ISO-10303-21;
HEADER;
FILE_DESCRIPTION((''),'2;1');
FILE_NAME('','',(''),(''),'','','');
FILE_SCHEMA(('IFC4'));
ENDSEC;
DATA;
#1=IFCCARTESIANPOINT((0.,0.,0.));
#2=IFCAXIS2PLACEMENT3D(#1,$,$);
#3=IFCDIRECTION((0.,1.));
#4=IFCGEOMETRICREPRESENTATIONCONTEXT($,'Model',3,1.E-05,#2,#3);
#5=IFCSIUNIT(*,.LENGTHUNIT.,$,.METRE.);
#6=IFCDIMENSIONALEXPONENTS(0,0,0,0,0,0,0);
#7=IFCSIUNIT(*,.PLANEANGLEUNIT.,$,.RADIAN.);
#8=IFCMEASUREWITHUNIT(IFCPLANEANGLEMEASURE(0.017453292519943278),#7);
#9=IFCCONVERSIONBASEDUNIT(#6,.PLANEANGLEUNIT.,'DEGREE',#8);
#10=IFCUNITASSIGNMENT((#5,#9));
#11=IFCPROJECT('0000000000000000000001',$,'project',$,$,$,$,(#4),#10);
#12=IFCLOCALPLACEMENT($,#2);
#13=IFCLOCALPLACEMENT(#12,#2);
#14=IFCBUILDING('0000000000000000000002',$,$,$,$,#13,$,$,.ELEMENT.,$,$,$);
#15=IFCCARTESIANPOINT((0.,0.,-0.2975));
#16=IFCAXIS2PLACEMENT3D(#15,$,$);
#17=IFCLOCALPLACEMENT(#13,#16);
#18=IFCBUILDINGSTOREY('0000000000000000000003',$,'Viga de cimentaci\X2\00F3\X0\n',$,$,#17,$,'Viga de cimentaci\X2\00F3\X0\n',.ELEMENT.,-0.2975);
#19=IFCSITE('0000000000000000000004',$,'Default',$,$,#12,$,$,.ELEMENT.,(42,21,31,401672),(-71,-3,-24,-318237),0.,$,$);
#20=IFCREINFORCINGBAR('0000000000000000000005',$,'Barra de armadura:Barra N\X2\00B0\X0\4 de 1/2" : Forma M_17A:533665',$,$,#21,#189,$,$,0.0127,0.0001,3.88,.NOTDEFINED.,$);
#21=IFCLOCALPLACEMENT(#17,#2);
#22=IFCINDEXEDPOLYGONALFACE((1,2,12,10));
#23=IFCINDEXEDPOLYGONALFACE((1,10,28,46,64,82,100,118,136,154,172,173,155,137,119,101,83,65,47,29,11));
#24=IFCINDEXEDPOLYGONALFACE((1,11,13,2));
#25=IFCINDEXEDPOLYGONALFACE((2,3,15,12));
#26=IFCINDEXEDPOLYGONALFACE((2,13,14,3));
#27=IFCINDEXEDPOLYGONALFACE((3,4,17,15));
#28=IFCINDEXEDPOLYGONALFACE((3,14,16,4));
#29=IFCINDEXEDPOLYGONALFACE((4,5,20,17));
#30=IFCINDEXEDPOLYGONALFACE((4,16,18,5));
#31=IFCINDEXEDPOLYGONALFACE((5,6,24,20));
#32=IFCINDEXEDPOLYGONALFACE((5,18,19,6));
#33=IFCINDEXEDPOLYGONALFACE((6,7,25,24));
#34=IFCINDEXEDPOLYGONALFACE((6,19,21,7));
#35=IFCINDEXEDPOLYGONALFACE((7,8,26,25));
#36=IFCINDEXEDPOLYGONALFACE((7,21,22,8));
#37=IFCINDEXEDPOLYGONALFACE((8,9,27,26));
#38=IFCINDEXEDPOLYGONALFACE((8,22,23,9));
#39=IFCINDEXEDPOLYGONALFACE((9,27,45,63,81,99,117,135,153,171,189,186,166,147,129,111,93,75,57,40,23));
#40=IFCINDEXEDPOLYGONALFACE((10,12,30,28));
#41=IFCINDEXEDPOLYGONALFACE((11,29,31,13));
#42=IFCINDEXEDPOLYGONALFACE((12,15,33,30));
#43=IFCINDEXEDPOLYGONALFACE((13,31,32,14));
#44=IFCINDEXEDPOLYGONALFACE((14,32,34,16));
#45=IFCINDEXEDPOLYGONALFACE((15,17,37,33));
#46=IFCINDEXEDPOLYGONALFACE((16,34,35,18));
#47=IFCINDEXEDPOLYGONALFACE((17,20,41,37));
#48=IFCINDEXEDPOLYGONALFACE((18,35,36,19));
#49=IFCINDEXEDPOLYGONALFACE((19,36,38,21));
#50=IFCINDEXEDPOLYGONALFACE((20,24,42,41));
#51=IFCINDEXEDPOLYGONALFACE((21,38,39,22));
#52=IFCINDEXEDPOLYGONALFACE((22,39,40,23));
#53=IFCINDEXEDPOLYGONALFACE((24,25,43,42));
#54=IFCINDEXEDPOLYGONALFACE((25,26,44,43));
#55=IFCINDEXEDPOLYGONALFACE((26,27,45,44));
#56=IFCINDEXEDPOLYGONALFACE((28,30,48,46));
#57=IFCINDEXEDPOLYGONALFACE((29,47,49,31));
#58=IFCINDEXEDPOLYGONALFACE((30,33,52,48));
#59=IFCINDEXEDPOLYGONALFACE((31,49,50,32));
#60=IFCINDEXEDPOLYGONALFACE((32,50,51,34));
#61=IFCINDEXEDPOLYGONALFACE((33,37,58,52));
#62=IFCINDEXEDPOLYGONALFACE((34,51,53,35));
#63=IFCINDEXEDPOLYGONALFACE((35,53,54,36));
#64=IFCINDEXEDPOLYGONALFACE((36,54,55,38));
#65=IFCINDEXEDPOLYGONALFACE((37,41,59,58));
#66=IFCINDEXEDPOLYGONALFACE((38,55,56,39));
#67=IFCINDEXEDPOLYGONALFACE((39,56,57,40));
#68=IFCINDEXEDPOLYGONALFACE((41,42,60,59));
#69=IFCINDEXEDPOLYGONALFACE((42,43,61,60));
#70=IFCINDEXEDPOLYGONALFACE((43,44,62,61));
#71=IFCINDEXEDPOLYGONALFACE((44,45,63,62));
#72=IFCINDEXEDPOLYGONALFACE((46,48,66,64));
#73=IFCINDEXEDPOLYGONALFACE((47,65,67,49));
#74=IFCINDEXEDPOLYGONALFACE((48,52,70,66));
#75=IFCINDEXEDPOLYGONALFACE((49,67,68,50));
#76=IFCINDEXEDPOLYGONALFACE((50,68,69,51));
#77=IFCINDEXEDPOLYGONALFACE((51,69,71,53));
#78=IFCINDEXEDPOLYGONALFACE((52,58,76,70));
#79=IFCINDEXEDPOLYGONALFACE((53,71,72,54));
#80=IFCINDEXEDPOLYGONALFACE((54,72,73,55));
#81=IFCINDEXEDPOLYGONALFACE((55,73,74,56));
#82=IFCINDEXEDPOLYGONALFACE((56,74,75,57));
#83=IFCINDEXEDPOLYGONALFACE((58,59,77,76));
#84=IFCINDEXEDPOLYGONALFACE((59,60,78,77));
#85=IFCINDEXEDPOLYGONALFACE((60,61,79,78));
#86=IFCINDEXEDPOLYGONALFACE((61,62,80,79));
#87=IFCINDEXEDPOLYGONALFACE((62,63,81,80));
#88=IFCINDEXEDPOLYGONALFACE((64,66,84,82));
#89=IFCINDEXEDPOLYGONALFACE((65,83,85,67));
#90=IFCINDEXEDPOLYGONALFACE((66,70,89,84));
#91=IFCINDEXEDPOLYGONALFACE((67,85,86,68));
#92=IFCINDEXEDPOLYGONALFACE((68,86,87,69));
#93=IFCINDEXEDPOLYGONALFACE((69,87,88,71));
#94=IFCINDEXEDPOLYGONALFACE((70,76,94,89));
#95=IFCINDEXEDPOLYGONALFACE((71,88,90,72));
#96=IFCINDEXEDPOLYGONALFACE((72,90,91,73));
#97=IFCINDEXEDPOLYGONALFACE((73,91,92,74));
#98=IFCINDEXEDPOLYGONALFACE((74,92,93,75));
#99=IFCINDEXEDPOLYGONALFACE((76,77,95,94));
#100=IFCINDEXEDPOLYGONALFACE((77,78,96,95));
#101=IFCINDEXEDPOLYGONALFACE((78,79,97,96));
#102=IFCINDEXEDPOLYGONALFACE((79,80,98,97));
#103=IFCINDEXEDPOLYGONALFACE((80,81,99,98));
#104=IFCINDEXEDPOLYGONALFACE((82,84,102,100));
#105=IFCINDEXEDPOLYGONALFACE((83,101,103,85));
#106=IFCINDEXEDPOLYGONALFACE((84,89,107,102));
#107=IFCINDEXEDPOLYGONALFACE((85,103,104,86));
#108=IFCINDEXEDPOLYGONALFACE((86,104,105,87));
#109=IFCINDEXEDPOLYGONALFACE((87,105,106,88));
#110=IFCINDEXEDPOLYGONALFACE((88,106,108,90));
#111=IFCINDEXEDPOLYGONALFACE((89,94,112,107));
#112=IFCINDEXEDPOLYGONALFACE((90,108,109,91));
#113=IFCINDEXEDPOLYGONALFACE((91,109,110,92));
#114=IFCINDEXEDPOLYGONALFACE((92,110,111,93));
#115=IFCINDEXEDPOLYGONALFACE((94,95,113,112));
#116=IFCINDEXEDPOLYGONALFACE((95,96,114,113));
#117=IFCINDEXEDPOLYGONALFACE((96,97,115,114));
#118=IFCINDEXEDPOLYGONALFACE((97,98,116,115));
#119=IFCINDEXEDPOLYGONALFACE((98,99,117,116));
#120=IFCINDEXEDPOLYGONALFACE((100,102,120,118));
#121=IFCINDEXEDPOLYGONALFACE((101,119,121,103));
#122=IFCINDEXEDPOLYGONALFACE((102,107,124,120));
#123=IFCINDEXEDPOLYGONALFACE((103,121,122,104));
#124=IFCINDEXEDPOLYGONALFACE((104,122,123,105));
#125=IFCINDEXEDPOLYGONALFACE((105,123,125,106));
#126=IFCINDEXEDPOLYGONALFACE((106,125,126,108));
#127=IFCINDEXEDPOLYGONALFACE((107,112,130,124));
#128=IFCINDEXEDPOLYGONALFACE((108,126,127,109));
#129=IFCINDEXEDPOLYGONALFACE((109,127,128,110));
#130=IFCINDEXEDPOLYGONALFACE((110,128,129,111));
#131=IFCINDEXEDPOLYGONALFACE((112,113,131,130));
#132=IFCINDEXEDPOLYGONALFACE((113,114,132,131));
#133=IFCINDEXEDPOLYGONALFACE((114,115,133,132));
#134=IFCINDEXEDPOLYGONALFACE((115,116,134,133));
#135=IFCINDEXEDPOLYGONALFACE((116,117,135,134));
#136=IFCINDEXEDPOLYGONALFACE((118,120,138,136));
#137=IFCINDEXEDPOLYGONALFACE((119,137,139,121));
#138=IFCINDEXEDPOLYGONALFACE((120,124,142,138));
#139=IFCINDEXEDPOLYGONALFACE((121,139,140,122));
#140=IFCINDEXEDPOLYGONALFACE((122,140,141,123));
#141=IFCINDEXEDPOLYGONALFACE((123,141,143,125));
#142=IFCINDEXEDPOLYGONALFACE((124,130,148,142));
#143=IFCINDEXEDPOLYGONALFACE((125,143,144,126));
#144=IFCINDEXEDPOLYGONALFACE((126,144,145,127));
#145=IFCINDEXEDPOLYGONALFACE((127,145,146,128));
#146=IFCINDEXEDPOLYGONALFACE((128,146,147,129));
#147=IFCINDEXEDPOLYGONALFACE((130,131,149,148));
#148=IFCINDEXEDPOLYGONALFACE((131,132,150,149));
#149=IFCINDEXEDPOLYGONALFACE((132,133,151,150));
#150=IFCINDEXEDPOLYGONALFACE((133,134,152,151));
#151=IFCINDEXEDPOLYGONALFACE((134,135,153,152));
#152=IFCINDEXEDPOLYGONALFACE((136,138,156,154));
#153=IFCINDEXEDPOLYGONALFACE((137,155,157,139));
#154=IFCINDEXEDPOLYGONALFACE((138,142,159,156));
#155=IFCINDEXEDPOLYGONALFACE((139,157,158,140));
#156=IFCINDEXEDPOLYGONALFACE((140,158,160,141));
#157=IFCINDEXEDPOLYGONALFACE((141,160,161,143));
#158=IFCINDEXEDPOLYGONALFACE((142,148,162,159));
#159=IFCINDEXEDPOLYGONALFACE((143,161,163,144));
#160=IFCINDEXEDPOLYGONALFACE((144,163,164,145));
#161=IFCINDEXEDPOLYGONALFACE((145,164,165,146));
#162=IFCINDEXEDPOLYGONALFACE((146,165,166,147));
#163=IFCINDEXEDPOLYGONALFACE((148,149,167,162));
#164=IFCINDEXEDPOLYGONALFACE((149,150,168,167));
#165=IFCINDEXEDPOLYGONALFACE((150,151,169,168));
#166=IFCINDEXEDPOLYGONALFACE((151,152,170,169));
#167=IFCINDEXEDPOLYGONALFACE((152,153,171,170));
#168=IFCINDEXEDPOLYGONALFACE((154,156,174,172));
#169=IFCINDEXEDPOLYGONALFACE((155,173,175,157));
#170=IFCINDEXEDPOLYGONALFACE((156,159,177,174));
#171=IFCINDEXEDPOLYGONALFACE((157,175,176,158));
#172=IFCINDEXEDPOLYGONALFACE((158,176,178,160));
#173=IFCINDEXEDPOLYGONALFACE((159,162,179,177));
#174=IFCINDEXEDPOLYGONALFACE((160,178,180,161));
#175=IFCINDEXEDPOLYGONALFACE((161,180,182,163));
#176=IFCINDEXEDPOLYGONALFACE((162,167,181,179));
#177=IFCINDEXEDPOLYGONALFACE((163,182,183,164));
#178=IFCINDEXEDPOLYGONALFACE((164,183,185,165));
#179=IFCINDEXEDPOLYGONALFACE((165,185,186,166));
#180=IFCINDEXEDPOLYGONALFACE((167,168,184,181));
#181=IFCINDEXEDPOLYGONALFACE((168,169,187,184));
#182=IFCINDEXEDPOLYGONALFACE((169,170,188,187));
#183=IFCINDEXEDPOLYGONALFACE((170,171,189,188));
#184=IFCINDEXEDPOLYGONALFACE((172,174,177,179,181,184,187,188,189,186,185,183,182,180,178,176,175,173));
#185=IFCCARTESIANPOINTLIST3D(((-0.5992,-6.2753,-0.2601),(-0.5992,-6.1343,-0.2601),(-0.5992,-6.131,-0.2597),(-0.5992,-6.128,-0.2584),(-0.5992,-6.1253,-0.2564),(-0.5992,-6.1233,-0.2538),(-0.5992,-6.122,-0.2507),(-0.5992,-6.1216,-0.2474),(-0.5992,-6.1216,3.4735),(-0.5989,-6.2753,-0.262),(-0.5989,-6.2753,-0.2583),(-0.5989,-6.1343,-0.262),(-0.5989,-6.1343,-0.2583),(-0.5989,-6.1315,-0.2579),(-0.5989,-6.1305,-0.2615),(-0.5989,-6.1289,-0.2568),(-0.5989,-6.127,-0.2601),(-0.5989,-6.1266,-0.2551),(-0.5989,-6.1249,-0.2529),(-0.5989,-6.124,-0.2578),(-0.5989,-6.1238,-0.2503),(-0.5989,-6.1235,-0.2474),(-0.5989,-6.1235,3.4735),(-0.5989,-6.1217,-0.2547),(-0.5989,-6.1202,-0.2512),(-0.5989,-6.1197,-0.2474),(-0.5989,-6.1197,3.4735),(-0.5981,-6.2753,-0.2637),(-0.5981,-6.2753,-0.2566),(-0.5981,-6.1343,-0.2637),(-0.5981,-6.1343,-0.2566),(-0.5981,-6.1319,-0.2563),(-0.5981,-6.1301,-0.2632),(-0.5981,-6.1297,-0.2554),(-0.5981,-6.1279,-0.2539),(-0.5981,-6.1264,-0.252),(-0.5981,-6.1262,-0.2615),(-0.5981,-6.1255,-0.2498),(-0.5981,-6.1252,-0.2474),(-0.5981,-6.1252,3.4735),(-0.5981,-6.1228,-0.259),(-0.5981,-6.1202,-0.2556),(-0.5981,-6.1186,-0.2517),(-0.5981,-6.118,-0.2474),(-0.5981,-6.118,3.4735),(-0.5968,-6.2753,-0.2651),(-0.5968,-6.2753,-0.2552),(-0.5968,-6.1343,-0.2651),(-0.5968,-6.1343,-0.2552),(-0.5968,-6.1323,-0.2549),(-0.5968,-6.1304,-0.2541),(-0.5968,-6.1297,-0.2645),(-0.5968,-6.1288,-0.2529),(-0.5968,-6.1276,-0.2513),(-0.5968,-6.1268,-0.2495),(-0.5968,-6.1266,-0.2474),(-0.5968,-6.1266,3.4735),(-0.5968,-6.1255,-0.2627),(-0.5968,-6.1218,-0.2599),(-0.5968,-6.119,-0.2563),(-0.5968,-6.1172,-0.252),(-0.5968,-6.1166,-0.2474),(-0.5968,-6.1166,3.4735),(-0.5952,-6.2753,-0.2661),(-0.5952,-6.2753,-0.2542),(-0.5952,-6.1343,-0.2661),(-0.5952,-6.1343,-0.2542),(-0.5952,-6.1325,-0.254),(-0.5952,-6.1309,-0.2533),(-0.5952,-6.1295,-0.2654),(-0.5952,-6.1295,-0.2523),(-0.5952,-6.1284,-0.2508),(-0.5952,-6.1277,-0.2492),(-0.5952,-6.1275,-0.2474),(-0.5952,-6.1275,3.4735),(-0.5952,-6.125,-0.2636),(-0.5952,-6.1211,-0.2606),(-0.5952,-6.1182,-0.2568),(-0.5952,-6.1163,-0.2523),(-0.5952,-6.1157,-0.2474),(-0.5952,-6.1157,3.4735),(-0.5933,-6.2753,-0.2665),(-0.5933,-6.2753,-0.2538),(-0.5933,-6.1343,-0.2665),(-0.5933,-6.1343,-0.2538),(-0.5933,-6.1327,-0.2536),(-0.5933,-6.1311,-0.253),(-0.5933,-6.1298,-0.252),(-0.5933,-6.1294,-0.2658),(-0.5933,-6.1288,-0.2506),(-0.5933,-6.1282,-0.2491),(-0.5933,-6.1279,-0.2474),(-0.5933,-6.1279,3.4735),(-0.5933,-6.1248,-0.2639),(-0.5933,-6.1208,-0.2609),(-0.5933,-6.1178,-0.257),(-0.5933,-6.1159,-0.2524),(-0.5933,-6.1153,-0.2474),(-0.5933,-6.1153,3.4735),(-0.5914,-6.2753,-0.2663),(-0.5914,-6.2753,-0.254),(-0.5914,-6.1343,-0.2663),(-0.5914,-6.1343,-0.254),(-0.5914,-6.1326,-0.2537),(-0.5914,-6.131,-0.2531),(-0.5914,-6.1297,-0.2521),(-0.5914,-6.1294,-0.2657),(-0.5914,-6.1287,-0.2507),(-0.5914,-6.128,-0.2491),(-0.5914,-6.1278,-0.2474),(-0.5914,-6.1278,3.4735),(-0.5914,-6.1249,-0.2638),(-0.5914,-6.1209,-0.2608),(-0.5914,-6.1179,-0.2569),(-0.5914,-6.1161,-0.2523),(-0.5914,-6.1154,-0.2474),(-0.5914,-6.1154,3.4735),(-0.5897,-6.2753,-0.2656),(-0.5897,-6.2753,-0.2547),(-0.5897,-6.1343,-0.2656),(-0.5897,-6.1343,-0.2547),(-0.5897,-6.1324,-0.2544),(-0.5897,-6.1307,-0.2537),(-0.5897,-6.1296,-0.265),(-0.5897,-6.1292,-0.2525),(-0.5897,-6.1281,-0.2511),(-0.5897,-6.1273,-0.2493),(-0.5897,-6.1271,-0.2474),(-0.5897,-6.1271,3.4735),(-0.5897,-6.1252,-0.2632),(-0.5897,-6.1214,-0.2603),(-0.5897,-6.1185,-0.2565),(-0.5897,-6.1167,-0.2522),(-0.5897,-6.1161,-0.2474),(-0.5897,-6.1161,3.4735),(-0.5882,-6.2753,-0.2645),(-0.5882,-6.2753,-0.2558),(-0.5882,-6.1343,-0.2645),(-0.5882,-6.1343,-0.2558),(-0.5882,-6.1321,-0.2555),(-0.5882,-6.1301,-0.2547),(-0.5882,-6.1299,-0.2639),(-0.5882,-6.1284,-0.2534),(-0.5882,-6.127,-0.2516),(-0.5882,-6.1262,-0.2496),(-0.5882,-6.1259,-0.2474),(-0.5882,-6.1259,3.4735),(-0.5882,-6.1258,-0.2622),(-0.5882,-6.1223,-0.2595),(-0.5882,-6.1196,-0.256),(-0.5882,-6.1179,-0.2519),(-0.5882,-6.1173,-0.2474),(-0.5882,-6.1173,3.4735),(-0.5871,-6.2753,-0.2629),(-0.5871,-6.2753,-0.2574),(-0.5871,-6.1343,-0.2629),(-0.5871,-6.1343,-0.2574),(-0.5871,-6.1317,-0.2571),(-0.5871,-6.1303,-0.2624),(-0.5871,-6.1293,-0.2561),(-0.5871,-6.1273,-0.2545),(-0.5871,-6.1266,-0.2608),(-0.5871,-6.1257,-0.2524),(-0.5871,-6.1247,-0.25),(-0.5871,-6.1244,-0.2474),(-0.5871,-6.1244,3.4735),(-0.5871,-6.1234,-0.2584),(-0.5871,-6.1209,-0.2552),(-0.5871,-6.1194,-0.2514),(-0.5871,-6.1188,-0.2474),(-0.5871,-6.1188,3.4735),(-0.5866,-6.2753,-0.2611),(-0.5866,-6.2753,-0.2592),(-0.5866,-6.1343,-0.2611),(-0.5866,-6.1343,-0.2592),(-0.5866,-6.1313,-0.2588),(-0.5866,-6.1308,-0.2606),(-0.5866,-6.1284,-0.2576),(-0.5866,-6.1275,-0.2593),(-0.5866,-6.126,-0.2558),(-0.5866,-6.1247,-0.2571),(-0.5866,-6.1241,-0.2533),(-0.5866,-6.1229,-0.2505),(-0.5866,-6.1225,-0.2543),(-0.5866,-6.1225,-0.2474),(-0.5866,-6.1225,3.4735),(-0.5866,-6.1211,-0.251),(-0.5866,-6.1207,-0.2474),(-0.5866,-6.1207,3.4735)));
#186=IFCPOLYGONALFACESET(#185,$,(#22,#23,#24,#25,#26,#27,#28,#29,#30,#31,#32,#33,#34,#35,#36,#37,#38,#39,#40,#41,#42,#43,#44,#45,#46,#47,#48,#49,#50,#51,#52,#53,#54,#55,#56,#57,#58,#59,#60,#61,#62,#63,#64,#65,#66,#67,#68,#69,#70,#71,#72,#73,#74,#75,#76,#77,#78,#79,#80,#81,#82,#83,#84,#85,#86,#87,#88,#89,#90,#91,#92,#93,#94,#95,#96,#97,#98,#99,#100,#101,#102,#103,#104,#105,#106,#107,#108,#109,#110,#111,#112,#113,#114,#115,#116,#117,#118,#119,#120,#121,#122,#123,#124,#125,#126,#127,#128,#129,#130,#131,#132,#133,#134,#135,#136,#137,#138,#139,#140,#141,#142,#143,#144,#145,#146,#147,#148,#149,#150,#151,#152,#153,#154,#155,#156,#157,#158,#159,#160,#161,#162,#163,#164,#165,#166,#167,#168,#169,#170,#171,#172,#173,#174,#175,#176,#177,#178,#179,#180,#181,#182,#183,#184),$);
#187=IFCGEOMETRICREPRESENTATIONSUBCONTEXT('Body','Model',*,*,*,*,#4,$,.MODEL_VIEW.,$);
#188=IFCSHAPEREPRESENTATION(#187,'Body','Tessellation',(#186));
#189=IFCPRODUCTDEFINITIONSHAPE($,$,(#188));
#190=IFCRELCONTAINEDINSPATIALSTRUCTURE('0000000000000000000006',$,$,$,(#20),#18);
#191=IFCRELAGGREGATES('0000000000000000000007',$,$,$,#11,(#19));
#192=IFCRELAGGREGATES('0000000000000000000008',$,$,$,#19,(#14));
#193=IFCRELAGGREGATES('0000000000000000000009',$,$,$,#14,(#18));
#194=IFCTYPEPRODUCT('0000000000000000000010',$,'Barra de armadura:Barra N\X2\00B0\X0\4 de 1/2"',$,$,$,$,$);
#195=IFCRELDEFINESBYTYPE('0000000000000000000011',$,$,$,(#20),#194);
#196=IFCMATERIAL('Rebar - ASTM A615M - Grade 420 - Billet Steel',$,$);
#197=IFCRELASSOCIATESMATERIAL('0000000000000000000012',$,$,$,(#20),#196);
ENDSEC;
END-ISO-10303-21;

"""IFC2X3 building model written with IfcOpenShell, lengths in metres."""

from ifc_helpers import new_model, entity, si_unit, converted_unit, direction, frame, origin, place, context, subcontext, project, spatial, material, type_object, element, save


model = new_model("IFC2X3")

# Units and contexts
model_context = context("Model", 3, precision=1e-05, world=origin(), true_north=direction((0.0, 1.0)))
body_context = subcontext(model_context, "Body", "Model", "MODEL_VIEW")
ifc_project = project(units=[si_unit("LENGTHUNIT", "METRE"), converted_unit("PLANEANGLEUNIT", "DEGREE", entity("IfcPlaneAngleMeasure", 0.017453292519943278), si_unit("PLANEANGLEUNIT", "RADIAN"), dimensions=[0, 0, 0, 0, 0, 0, 0])], contexts=[model_context])

# Site, building, storey
site_placement = place(None, origin())
site = spatial("IfcSite", under=ifc_project, at=site_placement, Name="Default", CompositionType="ELEMENT", RefLatitude=(42, 21, 31, 401672), RefLongitude=(-71, -3, -24, -318237), RefElevation=0.0)
building_placement = place(site_placement, origin())
building = spatial("IfcBuilding", under=site, at=building_placement, CompositionType="ELEMENT")
storey_placement = place(building_placement, frame((0.0, 0.0, -0.2975)))
storey = spatial("IfcBuildingStorey", under=building, at=storey_placement, Name="Viga de cimentación", LongName="Viga de cimentación", CompositionType="ELEMENT", Elevation=-0.2975)

# Reinforcing bar
ifc_material = material(Name="Rebar - ASTM A615M - Grade 420 - Billet Steel")
type_product_1 = type_object("IfcTypeProduct", Name="Barra de armadura:Barra N°4 de 1/2\"")
reinforcing_bar_1_placement = place(storey_placement, origin())
element("IfcReinforcingBar", 1, at=reinforcing_bar_1_placement, inside=storey, type_object=type_product_1, material=ifc_material, Name="Barra de armadura:Barra N°4 de 1/2\" : Forma M_17A:533665", BarLength=3.88, BarRole="NOTDEFINED", CrossSectionArea=0.0001, NominalDiameter=0.0127, context=body_context, shape_type="AdvancedSweptSolid", body=[
    entity("IfcSweptDiskSolid", entity("IfcCompositeCurve", [entity("IfcCompositeCurveSegment", "CONTINUOUS", True, entity("IfcPolyline", [entity("IfcCartesianPoint", [-0.5929, -6.1216, 3.4735]), entity("IfcCartesianPoint", [-0.5929, -6.1216, -0.2474])])), entity("IfcCompositeCurveSegment", "CONTINUOUS", True, entity("IfcTrimmedCurve", entity("IfcCircle", entity("IfcAxis2Placement3D", entity("IfcCartesianPoint", [-0.5929, -6.1343, -0.2474]), entity("IfcDirection", [-1.0, 0.0, 0.0]), entity("IfcDirection", [0.0, 0.0, -1.0])), 0.0127), [entity("IfcParameterValue", 270.0)], [entity("IfcParameterValue", 360.0)], True, "PARAMETER")), entity("IfcCompositeCurveSegment", "CONTINUOUS", True, entity("IfcPolyline", [entity("IfcCartesianPoint", [-0.5929, -6.1343, -0.2601]), entity("IfcCartesianPoint", [-0.5929, -6.2753, -0.2601])]))], False), 0.0063, None, 0.0, 92.0),
])

save(model, "model.ifc")
